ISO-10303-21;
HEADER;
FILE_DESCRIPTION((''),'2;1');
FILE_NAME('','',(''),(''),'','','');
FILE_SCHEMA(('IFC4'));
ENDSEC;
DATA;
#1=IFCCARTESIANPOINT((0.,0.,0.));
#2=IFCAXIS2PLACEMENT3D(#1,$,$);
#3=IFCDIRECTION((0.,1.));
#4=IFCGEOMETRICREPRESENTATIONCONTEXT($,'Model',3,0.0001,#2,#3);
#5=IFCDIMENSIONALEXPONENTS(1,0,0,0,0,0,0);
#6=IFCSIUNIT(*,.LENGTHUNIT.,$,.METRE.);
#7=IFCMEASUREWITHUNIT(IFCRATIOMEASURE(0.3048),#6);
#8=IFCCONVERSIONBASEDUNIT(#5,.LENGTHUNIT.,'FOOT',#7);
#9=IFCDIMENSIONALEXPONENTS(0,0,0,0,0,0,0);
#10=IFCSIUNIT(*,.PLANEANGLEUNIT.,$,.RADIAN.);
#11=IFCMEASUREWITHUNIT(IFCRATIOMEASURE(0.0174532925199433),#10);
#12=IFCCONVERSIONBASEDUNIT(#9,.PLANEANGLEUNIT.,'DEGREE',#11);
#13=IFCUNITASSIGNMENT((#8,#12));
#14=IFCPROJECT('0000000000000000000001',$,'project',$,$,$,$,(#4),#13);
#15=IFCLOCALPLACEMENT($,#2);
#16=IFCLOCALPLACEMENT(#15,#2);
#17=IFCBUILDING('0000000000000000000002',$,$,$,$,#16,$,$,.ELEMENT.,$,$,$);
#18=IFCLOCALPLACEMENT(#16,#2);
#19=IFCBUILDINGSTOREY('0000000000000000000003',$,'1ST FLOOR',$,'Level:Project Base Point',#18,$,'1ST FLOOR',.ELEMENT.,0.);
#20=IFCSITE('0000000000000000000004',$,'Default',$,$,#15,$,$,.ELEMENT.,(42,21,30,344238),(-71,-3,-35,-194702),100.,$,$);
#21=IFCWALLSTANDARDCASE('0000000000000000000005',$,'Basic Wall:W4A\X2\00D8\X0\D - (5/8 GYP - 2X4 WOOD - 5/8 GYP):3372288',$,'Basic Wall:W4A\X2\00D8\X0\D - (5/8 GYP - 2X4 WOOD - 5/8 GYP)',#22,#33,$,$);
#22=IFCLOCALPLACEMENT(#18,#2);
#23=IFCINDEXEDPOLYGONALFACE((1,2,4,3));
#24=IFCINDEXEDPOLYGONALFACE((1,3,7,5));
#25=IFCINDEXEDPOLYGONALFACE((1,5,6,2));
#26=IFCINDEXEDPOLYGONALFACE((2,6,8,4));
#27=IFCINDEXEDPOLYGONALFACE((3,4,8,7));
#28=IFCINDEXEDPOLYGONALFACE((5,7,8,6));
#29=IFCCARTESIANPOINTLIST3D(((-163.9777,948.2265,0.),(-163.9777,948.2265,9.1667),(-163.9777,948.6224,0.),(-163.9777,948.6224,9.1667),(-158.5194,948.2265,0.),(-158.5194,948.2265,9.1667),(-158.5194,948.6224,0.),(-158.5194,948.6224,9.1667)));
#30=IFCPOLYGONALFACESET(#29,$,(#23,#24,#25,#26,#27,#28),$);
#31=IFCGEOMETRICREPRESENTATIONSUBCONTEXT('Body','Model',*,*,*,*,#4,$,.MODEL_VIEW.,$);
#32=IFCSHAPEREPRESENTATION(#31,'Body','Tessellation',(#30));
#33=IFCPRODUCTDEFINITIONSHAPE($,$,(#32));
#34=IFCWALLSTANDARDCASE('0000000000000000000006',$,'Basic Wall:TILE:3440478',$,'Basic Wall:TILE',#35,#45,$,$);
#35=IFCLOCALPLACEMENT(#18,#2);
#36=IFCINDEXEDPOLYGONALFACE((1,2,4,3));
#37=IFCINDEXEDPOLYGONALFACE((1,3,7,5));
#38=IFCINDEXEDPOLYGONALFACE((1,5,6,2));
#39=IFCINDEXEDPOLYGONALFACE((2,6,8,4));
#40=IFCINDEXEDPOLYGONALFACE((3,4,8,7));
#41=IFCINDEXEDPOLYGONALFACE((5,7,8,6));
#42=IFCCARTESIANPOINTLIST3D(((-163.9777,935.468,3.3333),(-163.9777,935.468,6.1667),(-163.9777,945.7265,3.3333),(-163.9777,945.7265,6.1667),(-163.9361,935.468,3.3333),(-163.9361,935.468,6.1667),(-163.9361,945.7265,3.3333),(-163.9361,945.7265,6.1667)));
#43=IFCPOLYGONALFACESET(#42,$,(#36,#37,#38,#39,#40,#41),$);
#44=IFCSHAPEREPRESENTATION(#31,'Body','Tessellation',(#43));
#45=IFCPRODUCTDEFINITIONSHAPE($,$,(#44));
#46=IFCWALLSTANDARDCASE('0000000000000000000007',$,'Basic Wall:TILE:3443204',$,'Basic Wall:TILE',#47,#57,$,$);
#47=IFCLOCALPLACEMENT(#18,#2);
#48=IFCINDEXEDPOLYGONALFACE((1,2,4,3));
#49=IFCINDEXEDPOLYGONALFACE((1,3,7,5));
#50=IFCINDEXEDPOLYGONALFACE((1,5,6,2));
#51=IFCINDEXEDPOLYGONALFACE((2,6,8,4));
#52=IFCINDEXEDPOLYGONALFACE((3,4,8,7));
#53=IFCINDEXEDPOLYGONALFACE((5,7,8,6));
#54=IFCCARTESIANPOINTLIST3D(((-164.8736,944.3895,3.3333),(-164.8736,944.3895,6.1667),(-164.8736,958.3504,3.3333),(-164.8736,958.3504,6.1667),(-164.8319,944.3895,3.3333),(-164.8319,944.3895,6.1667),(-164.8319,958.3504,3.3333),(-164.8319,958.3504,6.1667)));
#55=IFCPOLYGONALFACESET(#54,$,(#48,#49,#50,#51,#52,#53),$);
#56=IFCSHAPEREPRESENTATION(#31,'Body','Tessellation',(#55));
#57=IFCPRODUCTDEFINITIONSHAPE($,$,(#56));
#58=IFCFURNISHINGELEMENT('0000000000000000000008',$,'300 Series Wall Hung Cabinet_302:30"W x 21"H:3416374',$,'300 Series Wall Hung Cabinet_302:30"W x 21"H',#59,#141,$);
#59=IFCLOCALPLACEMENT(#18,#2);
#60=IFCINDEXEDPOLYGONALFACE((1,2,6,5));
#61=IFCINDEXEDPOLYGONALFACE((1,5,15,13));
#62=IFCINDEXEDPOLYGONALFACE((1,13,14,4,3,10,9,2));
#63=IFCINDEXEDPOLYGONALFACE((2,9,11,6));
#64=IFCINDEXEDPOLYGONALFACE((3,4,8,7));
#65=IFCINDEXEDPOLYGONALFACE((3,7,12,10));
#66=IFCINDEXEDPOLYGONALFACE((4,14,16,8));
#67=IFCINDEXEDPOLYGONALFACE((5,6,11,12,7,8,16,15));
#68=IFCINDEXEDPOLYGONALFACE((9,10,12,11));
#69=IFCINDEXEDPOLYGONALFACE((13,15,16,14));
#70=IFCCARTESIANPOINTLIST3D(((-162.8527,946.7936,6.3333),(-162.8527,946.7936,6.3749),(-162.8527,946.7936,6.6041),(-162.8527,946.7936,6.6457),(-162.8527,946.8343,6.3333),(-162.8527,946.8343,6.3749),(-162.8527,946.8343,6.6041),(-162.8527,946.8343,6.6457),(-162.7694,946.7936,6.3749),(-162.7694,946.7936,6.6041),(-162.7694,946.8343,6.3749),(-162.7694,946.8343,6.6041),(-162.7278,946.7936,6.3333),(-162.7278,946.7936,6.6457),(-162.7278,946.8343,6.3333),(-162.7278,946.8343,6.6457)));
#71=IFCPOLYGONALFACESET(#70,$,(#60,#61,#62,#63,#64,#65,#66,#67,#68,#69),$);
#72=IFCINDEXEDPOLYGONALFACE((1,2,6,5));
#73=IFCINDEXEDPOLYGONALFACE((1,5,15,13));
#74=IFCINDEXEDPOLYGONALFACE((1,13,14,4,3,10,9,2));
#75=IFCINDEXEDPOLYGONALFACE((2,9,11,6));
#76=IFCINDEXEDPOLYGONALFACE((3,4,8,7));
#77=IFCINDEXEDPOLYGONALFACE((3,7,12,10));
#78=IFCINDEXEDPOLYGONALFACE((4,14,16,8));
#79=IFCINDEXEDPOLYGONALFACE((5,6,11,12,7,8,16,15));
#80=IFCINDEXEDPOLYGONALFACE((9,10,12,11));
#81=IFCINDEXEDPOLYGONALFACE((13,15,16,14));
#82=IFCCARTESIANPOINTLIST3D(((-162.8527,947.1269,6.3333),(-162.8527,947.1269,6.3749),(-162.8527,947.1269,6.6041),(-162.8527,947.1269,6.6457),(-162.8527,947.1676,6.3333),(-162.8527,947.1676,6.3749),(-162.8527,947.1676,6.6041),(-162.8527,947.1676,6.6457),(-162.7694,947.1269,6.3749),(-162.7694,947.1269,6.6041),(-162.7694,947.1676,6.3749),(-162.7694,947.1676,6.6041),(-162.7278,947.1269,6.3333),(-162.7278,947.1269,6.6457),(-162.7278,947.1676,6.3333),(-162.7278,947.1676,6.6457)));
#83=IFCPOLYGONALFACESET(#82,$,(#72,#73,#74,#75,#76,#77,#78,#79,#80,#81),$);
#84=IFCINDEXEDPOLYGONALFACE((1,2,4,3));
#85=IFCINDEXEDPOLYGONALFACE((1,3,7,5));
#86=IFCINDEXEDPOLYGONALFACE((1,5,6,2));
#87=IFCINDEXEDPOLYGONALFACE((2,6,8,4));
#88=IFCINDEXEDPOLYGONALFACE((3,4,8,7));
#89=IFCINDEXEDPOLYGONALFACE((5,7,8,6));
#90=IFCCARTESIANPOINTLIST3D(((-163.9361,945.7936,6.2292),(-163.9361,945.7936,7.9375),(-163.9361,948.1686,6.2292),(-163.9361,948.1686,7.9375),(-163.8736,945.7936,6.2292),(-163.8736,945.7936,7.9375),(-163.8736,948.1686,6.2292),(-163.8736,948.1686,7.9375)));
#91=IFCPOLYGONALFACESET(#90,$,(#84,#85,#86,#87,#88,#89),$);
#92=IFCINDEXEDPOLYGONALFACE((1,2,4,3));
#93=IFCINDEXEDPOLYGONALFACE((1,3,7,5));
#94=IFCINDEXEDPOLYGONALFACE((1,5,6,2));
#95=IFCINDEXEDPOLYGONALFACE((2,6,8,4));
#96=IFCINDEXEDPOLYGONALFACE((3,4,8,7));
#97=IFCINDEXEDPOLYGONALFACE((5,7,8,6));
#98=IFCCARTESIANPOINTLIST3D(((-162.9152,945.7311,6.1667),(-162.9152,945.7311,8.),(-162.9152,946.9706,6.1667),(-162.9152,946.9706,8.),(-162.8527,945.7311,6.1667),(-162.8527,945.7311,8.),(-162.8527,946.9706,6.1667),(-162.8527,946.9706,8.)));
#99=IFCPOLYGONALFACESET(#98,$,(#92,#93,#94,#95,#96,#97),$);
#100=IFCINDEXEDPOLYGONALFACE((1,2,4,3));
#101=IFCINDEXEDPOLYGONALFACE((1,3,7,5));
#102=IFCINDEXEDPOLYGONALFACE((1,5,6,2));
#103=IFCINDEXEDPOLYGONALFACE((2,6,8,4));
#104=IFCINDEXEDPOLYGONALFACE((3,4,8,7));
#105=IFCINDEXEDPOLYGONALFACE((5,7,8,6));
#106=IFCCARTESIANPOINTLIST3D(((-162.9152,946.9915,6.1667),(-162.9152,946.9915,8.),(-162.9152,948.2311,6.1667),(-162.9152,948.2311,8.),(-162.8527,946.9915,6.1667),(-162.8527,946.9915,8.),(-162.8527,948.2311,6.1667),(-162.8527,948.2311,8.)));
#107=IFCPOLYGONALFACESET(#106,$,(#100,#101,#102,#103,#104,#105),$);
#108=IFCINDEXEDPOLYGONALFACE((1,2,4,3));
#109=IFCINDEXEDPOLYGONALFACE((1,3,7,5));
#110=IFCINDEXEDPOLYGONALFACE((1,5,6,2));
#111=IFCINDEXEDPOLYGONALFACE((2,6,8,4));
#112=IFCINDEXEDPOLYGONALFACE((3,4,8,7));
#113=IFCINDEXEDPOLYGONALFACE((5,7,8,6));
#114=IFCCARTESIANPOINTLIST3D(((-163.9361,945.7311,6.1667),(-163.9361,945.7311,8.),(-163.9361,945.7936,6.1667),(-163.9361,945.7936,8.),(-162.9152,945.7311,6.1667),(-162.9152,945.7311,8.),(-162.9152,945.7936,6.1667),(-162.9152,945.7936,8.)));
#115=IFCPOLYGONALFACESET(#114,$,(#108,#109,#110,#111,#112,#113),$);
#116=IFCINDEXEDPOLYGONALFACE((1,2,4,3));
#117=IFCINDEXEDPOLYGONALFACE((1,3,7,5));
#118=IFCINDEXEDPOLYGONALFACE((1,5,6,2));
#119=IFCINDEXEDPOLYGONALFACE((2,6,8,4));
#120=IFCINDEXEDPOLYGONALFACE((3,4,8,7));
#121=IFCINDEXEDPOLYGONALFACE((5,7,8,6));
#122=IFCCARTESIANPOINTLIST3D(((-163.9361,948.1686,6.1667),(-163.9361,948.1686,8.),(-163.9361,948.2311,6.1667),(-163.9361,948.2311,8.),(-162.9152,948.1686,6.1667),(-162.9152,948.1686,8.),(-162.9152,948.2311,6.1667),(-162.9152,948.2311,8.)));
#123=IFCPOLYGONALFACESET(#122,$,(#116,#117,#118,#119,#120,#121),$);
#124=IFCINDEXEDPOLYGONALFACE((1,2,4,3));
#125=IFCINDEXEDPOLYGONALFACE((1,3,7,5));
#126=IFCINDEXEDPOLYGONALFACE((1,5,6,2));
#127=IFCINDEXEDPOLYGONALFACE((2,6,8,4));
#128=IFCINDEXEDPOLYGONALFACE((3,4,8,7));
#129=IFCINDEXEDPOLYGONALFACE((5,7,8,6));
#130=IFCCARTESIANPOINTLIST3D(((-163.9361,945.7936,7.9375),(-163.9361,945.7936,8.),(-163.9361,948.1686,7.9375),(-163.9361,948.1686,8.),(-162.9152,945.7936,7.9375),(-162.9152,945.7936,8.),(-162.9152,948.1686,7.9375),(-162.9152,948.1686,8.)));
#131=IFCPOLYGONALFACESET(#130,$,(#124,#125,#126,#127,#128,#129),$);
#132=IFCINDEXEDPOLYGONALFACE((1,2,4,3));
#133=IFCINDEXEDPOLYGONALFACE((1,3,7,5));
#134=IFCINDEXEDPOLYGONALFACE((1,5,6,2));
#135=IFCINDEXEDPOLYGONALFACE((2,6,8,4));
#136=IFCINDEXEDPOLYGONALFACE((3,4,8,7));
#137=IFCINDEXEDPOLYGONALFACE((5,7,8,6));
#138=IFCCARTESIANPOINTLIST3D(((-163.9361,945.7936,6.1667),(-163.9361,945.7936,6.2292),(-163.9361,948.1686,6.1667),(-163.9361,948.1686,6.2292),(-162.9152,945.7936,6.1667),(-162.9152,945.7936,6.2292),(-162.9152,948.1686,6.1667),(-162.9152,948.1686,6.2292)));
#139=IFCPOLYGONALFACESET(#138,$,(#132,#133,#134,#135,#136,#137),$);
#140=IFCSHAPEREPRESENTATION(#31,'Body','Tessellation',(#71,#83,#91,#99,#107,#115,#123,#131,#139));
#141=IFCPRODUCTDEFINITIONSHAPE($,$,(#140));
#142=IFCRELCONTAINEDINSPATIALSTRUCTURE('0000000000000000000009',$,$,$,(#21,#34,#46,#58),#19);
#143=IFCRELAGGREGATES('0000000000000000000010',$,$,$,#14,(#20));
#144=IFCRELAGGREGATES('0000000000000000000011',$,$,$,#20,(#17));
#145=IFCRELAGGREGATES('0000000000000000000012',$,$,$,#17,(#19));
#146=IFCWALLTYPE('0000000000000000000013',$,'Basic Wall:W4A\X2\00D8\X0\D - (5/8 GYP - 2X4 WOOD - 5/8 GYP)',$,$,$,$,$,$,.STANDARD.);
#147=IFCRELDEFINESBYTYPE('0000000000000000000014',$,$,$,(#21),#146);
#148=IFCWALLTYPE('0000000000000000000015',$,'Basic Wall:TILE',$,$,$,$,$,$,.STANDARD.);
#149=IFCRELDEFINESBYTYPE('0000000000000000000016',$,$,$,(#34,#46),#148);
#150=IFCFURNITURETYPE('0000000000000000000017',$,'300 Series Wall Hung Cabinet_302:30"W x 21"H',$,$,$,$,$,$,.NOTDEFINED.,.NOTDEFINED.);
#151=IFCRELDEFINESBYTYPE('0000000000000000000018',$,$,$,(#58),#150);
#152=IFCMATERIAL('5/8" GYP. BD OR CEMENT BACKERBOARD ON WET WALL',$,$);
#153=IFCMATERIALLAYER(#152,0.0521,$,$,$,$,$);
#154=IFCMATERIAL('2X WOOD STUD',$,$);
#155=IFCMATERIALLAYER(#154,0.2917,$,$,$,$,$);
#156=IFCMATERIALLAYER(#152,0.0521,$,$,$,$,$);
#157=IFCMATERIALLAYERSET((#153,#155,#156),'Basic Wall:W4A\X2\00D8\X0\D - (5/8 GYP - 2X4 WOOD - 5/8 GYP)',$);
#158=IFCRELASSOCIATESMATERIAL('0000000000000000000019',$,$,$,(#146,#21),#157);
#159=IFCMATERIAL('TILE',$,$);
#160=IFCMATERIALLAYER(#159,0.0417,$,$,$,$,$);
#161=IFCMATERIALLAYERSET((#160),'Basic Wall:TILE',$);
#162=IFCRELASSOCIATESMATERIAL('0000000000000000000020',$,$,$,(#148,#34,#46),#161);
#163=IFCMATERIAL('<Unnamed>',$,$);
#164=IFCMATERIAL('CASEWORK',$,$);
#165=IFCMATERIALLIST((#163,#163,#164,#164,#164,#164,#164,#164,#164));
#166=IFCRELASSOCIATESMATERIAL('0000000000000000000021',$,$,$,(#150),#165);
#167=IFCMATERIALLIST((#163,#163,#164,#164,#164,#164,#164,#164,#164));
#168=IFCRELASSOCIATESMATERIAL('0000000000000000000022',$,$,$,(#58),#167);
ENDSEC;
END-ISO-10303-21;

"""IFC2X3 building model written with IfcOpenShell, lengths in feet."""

from ifc_helpers import new_model, entity, si_unit, converted_unit, direction, frame, frame_2d, origin, origin_2d_with_axis, place, context, subcontext, project, spatial, polyline, rectangle, outline, extrude, source, transform, mapped, material, material_list, layer, layer_set, layer_usage, type_object, type_shapes, element, save


model = new_model("IFC2X3")

# Units and contexts
model_context = context("Model", 3, precision=0.0001, world=origin(), true_north=direction((0.0, 1.0)))
body_context = subcontext(model_context, "Body", "Model", "MODEL_VIEW")
ifc_project = project(units=[converted_unit("LENGTHUNIT", "FOOT", entity("IfcRatioMeasure", 0.3048), si_unit("LENGTHUNIT", "METRE"), dimensions=[1, 0, 0, 0, 0, 0, 0]), converted_unit("PLANEANGLEUNIT", "DEGREE", entity("IfcRatioMeasure", 0.0174532925199433), si_unit("PLANEANGLEUNIT", "RADIAN"), dimensions=[0, 0, 0, 0, 0, 0, 0])], contexts=[model_context])

# Site, building, storey
site_placement = place(None, origin())
site = spatial("IfcSite", under=ifc_project, at=site_placement, Name="Default", CompositionType="ELEMENT", RefLatitude=(42, 21, 30, 344238), RefLongitude=(-71, -3, -35, -194702), RefElevation=100.0)
building_placement = place(site_placement, origin())
building = spatial("IfcBuilding", under=site, at=building_placement, CompositionType="ELEMENT")
storey_placement = place(building_placement, origin())
storey = spatial("IfcBuildingStorey", under=building, at=storey_placement, Name="1ST FLOOR", ObjectType="Level:Project Base Point", LongName="1ST FLOOR", CompositionType="ELEMENT", Elevation=0.0)

# Shared definitions
ifc_material_1 = material(Name="5/8\" GYP. BD OR CEMENT BACKERBOARD ON WET WALL")
ifc_layer_1 = layer(ifc_material_1, 0.0521)
ifc_material_2 = material(Name="2X WOOD STUD")
ifc_layer_2 = layer(ifc_material_2, 0.2917)
ifc_layer_3 = layer(ifc_material_1, 0.0521)
ifc_layer_set_1 = layer_set([ifc_layer_1, ifc_layer_2, ifc_layer_3], Name="Basic Wall:W4AØD - (5/8 GYP - 2X4 WOOD - 5/8 GYP)")
wall_type_1 = type_object("IfcWallType", Name="Basic Wall:W4AØD - (5/8 GYP - 2X4 WOOD - 5/8 GYP)", PredefinedType="STANDARD", material=ifc_layer_set_1)

# Wall
ifc_layer_usage_1 = layer_usage(ifc_layer_set_1, "AXIS2", "POSITIVE", -0.1979)
wall_1_placement = place(storey_placement, frame((-158.5194, 948.4244, 0.0), z_axis=(0.0, 0.0, 1.0), x_axis=(-1.0, 0.0, 0.0)))
element("IfcWallStandardCase", 1, at=wall_1_placement, inside=storey, type_object=wall_type_1, material=ifc_layer_usage_1, Name="Basic Wall:W4AØD - (5/8 GYP - 2X4 WOOD - 5/8 GYP):3372288", ObjectType="Basic Wall:W4AØD - (5/8 GYP - 2X4 WOOD - 5/8 GYP)", context=body_context, shape_type="SweptSolid", body=[
    extrude(rectangle(XDim=5.4583, YDim=0.3958, at=frame_2d((2.7292, 0.0), x_axis=(-1.0, 0.0))), origin(), (0.0, 0.0, 1.0), 9.1667),
])

# Walls
ifc_material_3 = material(Name="TILE")
ifc_layer_4 = layer(ifc_material_3, 0.0417)
ifc_layer_set_2 = layer_set([ifc_layer_4], Name="Basic Wall:TILE")
ifc_layer_usage_2 = layer_usage(ifc_layer_set_2, "AXIS2", "POSITIVE", -0.0208)
wall_type_2 = type_object("IfcWallType", Name="Basic Wall:TILE", PredefinedType="STANDARD", material=ifc_layer_set_2)
wall_2_placement = place(storey_placement, frame((-163.9569, 945.7265, 3.3333), z_axis=(0.0, 0.0, 1.0), x_axis=(0.0, -1.0, 0.0)))
element("IfcWallStandardCase", 2, at=wall_2_placement, inside=storey, type_object=wall_type_2, material=ifc_layer_usage_2, Name="Basic Wall:TILE:3440478", ObjectType="Basic Wall:TILE", context=body_context, shape_type="SweptSolid", body=[
    extrude(rectangle(XDim=10.2585, YDim=0.0417, at=frame_2d((5.1292, 0.0), x_axis=(-1.0, 0.0))), origin(), (0.0, 0.0, 1.0), 2.8333),
])
ifc_layer_usage_3 = layer_usage(ifc_layer_set_2, "AXIS2", "NEGATIVE", 0.0208)
wall_3_placement = place(storey_placement, frame((-164.8527, 958.3504, 3.3333), z_axis=(0.0, 0.0, 1.0), x_axis=(0.0, -1.0, 0.0)))
element("IfcWallStandardCase", 3, at=wall_3_placement, inside=storey, type_object=wall_type_2, material=ifc_layer_usage_3, Name="Basic Wall:TILE:3443204", ObjectType="Basic Wall:TILE", context=body_context, shape_type="SweptSolid", body=[
    extrude(rectangle(XDim=13.9609, YDim=0.0417, at=frame_2d((6.9805, 0.0), x_axis=(-1.0, 0.0))), origin(), (0.0, 0.0, 1.0), 2.8333),
])

# Shared definitions
ifc_material_4 = material(Name="CASEWORK")

# Furnishing element
ifc_material_5 = material(Name="<Unnamed>")
ifc_material_list_1 = material_list([ifc_material_5, ifc_material_5, ifc_material_4, ifc_material_4, ifc_material_4, ifc_material_4, ifc_material_4, ifc_material_4, ifc_material_4])
ifc_material_list_2 = material_list([ifc_material_5, ifc_material_5, ifc_material_4, ifc_material_4, ifc_material_4, ifc_material_4, ifc_material_4, ifc_material_4, ifc_material_4])
furniture_type_1 = type_object("IfcFurnitureType", Name="300 Series Wall Hung Cabinet_302:30\"W x 21\"H", material=ifc_material_list_2)
shared_shape_1 = source(origin(), body_context, "Body", "SweptSolid", [
    extrude(outline(polyline([(0.1146, -0.0521), (0.1562, -0.0521), (0.1562, 0.0729), (-0.1562, 0.0729), (-0.1562, -0.0521), (-0.1146, -0.0521), (-0.1146, 0.0313), (0.1146, 0.0313), (0.1146, -0.0521)])), frame((1.0625, 0.0729, 0.3229), z_axis=(1.0, 0.0, 0.0), x_axis=(0.0, 0.0, 1.0)), (0.0, 0.0, 1.0), 0.0407),
    extrude(outline(polyline([(0.1146, -0.0521), (0.1562, -0.0521), (0.1562, 0.0729), (-0.1562, 0.0729), (-0.1562, -0.0521), (-0.1146, -0.0521), (-0.1146, 0.0313), (0.1146, 0.0313), (0.1146, -0.0521)])), frame((1.3958, 0.0729, 0.3229), z_axis=(1.0, 0.0, 0.0), x_axis=(0.0, 0.0, 1.0)), (0.0, 0.0, 1.0), 0.0407),
    extrude(rectangle(XDim=2.375, YDim=0.0625, at=origin_2d_with_axis()), frame((1.25, 1.177, 0.0625), z_axis=(0.0, 0.0, 1.0), x_axis=(-1.0, 0.0, 0.0)), (0.0, 0.0, 1.0), 1.7083),
    extrude(rectangle(XDim=1.2396, YDim=0.0625, at=origin_2d_with_axis()), frame((0.6198, 0.1562, 0.0), z_axis=(0.0, 0.0, 1.0), x_axis=(-1.0, 0.0, 0.0)), (0.0, 0.0, 1.0), 1.8333),
    extrude(rectangle(XDim=1.2396, YDim=0.0625, at=origin_2d_with_axis()), frame((1.8802, 0.1562, 0.0), z_axis=(0.0, 0.0, 1.0), x_axis=(-1.0, 0.0, 0.0)), (0.0, 0.0, 1.0), 1.8333),
    extrude(rectangle(XDim=1.0208, YDim=0.0625, at=frame_2d((0.0, 0.0), x_axis=(1.0, 0.0))), frame((0.0313, 0.6979, 0.0), z_axis=(0.0, 0.0, 1.0), x_axis=(0.0, -1.0, 0.0)), (0.0, 0.0, 1.0), 1.8333),
    extrude(rectangle(XDim=1.0208, YDim=0.0625, at=frame_2d((0.0, 0.0), x_axis=(1.0, 0.0))), frame((2.4688, 0.6979, 0.0), z_axis=(0.0, 0.0, 1.0), x_axis=(0.0, -1.0, 0.0)), (0.0, 0.0, 1.0), 1.8333),
    extrude(rectangle(XDim=1.0208, YDim=2.375, at=origin_2d_with_axis()), frame((1.25, 0.6979, 1.7708), z_axis=(0.0, 0.0, 1.0), x_axis=(0.0, 1.0, 0.0)), (0.0, 0.0, 1.0), 0.0625),
    extrude(rectangle(XDim=1.0208, YDim=2.375, at=origin_2d_with_axis()), frame((1.25, 0.6979, 0.0), z_axis=(0.0, 0.0, 1.0), x_axis=(0.0, 1.0, 0.0)), (0.0, 0.0, 1.0), 0.0625),
])
type_shapes(furniture_type_1, [shared_shape_1])
furnishing_1_placement = place(storey_placement, frame((-162.7278, 945.7311, 6.1667), z_axis=(0.0, 0.0, 1.0), x_axis=(0.0, 1.0, 0.0)))
element("IfcFurnishingElement", 4, at=furnishing_1_placement, inside=storey, type_object=furniture_type_1, material=ifc_material_list_1, Name="300 Series Wall Hung Cabinet_302:30\"W x 21\"H:3416374", ObjectType="300 Series Wall Hung Cabinet_302:30\"W x 21\"H", context=body_context, shape_type="MappedRepresentation", body=[
    mapped(shared_shape_1, transform((0.0, 0.0, 0.0), scale=1.0)),
])

save(model, "model.ifc")
